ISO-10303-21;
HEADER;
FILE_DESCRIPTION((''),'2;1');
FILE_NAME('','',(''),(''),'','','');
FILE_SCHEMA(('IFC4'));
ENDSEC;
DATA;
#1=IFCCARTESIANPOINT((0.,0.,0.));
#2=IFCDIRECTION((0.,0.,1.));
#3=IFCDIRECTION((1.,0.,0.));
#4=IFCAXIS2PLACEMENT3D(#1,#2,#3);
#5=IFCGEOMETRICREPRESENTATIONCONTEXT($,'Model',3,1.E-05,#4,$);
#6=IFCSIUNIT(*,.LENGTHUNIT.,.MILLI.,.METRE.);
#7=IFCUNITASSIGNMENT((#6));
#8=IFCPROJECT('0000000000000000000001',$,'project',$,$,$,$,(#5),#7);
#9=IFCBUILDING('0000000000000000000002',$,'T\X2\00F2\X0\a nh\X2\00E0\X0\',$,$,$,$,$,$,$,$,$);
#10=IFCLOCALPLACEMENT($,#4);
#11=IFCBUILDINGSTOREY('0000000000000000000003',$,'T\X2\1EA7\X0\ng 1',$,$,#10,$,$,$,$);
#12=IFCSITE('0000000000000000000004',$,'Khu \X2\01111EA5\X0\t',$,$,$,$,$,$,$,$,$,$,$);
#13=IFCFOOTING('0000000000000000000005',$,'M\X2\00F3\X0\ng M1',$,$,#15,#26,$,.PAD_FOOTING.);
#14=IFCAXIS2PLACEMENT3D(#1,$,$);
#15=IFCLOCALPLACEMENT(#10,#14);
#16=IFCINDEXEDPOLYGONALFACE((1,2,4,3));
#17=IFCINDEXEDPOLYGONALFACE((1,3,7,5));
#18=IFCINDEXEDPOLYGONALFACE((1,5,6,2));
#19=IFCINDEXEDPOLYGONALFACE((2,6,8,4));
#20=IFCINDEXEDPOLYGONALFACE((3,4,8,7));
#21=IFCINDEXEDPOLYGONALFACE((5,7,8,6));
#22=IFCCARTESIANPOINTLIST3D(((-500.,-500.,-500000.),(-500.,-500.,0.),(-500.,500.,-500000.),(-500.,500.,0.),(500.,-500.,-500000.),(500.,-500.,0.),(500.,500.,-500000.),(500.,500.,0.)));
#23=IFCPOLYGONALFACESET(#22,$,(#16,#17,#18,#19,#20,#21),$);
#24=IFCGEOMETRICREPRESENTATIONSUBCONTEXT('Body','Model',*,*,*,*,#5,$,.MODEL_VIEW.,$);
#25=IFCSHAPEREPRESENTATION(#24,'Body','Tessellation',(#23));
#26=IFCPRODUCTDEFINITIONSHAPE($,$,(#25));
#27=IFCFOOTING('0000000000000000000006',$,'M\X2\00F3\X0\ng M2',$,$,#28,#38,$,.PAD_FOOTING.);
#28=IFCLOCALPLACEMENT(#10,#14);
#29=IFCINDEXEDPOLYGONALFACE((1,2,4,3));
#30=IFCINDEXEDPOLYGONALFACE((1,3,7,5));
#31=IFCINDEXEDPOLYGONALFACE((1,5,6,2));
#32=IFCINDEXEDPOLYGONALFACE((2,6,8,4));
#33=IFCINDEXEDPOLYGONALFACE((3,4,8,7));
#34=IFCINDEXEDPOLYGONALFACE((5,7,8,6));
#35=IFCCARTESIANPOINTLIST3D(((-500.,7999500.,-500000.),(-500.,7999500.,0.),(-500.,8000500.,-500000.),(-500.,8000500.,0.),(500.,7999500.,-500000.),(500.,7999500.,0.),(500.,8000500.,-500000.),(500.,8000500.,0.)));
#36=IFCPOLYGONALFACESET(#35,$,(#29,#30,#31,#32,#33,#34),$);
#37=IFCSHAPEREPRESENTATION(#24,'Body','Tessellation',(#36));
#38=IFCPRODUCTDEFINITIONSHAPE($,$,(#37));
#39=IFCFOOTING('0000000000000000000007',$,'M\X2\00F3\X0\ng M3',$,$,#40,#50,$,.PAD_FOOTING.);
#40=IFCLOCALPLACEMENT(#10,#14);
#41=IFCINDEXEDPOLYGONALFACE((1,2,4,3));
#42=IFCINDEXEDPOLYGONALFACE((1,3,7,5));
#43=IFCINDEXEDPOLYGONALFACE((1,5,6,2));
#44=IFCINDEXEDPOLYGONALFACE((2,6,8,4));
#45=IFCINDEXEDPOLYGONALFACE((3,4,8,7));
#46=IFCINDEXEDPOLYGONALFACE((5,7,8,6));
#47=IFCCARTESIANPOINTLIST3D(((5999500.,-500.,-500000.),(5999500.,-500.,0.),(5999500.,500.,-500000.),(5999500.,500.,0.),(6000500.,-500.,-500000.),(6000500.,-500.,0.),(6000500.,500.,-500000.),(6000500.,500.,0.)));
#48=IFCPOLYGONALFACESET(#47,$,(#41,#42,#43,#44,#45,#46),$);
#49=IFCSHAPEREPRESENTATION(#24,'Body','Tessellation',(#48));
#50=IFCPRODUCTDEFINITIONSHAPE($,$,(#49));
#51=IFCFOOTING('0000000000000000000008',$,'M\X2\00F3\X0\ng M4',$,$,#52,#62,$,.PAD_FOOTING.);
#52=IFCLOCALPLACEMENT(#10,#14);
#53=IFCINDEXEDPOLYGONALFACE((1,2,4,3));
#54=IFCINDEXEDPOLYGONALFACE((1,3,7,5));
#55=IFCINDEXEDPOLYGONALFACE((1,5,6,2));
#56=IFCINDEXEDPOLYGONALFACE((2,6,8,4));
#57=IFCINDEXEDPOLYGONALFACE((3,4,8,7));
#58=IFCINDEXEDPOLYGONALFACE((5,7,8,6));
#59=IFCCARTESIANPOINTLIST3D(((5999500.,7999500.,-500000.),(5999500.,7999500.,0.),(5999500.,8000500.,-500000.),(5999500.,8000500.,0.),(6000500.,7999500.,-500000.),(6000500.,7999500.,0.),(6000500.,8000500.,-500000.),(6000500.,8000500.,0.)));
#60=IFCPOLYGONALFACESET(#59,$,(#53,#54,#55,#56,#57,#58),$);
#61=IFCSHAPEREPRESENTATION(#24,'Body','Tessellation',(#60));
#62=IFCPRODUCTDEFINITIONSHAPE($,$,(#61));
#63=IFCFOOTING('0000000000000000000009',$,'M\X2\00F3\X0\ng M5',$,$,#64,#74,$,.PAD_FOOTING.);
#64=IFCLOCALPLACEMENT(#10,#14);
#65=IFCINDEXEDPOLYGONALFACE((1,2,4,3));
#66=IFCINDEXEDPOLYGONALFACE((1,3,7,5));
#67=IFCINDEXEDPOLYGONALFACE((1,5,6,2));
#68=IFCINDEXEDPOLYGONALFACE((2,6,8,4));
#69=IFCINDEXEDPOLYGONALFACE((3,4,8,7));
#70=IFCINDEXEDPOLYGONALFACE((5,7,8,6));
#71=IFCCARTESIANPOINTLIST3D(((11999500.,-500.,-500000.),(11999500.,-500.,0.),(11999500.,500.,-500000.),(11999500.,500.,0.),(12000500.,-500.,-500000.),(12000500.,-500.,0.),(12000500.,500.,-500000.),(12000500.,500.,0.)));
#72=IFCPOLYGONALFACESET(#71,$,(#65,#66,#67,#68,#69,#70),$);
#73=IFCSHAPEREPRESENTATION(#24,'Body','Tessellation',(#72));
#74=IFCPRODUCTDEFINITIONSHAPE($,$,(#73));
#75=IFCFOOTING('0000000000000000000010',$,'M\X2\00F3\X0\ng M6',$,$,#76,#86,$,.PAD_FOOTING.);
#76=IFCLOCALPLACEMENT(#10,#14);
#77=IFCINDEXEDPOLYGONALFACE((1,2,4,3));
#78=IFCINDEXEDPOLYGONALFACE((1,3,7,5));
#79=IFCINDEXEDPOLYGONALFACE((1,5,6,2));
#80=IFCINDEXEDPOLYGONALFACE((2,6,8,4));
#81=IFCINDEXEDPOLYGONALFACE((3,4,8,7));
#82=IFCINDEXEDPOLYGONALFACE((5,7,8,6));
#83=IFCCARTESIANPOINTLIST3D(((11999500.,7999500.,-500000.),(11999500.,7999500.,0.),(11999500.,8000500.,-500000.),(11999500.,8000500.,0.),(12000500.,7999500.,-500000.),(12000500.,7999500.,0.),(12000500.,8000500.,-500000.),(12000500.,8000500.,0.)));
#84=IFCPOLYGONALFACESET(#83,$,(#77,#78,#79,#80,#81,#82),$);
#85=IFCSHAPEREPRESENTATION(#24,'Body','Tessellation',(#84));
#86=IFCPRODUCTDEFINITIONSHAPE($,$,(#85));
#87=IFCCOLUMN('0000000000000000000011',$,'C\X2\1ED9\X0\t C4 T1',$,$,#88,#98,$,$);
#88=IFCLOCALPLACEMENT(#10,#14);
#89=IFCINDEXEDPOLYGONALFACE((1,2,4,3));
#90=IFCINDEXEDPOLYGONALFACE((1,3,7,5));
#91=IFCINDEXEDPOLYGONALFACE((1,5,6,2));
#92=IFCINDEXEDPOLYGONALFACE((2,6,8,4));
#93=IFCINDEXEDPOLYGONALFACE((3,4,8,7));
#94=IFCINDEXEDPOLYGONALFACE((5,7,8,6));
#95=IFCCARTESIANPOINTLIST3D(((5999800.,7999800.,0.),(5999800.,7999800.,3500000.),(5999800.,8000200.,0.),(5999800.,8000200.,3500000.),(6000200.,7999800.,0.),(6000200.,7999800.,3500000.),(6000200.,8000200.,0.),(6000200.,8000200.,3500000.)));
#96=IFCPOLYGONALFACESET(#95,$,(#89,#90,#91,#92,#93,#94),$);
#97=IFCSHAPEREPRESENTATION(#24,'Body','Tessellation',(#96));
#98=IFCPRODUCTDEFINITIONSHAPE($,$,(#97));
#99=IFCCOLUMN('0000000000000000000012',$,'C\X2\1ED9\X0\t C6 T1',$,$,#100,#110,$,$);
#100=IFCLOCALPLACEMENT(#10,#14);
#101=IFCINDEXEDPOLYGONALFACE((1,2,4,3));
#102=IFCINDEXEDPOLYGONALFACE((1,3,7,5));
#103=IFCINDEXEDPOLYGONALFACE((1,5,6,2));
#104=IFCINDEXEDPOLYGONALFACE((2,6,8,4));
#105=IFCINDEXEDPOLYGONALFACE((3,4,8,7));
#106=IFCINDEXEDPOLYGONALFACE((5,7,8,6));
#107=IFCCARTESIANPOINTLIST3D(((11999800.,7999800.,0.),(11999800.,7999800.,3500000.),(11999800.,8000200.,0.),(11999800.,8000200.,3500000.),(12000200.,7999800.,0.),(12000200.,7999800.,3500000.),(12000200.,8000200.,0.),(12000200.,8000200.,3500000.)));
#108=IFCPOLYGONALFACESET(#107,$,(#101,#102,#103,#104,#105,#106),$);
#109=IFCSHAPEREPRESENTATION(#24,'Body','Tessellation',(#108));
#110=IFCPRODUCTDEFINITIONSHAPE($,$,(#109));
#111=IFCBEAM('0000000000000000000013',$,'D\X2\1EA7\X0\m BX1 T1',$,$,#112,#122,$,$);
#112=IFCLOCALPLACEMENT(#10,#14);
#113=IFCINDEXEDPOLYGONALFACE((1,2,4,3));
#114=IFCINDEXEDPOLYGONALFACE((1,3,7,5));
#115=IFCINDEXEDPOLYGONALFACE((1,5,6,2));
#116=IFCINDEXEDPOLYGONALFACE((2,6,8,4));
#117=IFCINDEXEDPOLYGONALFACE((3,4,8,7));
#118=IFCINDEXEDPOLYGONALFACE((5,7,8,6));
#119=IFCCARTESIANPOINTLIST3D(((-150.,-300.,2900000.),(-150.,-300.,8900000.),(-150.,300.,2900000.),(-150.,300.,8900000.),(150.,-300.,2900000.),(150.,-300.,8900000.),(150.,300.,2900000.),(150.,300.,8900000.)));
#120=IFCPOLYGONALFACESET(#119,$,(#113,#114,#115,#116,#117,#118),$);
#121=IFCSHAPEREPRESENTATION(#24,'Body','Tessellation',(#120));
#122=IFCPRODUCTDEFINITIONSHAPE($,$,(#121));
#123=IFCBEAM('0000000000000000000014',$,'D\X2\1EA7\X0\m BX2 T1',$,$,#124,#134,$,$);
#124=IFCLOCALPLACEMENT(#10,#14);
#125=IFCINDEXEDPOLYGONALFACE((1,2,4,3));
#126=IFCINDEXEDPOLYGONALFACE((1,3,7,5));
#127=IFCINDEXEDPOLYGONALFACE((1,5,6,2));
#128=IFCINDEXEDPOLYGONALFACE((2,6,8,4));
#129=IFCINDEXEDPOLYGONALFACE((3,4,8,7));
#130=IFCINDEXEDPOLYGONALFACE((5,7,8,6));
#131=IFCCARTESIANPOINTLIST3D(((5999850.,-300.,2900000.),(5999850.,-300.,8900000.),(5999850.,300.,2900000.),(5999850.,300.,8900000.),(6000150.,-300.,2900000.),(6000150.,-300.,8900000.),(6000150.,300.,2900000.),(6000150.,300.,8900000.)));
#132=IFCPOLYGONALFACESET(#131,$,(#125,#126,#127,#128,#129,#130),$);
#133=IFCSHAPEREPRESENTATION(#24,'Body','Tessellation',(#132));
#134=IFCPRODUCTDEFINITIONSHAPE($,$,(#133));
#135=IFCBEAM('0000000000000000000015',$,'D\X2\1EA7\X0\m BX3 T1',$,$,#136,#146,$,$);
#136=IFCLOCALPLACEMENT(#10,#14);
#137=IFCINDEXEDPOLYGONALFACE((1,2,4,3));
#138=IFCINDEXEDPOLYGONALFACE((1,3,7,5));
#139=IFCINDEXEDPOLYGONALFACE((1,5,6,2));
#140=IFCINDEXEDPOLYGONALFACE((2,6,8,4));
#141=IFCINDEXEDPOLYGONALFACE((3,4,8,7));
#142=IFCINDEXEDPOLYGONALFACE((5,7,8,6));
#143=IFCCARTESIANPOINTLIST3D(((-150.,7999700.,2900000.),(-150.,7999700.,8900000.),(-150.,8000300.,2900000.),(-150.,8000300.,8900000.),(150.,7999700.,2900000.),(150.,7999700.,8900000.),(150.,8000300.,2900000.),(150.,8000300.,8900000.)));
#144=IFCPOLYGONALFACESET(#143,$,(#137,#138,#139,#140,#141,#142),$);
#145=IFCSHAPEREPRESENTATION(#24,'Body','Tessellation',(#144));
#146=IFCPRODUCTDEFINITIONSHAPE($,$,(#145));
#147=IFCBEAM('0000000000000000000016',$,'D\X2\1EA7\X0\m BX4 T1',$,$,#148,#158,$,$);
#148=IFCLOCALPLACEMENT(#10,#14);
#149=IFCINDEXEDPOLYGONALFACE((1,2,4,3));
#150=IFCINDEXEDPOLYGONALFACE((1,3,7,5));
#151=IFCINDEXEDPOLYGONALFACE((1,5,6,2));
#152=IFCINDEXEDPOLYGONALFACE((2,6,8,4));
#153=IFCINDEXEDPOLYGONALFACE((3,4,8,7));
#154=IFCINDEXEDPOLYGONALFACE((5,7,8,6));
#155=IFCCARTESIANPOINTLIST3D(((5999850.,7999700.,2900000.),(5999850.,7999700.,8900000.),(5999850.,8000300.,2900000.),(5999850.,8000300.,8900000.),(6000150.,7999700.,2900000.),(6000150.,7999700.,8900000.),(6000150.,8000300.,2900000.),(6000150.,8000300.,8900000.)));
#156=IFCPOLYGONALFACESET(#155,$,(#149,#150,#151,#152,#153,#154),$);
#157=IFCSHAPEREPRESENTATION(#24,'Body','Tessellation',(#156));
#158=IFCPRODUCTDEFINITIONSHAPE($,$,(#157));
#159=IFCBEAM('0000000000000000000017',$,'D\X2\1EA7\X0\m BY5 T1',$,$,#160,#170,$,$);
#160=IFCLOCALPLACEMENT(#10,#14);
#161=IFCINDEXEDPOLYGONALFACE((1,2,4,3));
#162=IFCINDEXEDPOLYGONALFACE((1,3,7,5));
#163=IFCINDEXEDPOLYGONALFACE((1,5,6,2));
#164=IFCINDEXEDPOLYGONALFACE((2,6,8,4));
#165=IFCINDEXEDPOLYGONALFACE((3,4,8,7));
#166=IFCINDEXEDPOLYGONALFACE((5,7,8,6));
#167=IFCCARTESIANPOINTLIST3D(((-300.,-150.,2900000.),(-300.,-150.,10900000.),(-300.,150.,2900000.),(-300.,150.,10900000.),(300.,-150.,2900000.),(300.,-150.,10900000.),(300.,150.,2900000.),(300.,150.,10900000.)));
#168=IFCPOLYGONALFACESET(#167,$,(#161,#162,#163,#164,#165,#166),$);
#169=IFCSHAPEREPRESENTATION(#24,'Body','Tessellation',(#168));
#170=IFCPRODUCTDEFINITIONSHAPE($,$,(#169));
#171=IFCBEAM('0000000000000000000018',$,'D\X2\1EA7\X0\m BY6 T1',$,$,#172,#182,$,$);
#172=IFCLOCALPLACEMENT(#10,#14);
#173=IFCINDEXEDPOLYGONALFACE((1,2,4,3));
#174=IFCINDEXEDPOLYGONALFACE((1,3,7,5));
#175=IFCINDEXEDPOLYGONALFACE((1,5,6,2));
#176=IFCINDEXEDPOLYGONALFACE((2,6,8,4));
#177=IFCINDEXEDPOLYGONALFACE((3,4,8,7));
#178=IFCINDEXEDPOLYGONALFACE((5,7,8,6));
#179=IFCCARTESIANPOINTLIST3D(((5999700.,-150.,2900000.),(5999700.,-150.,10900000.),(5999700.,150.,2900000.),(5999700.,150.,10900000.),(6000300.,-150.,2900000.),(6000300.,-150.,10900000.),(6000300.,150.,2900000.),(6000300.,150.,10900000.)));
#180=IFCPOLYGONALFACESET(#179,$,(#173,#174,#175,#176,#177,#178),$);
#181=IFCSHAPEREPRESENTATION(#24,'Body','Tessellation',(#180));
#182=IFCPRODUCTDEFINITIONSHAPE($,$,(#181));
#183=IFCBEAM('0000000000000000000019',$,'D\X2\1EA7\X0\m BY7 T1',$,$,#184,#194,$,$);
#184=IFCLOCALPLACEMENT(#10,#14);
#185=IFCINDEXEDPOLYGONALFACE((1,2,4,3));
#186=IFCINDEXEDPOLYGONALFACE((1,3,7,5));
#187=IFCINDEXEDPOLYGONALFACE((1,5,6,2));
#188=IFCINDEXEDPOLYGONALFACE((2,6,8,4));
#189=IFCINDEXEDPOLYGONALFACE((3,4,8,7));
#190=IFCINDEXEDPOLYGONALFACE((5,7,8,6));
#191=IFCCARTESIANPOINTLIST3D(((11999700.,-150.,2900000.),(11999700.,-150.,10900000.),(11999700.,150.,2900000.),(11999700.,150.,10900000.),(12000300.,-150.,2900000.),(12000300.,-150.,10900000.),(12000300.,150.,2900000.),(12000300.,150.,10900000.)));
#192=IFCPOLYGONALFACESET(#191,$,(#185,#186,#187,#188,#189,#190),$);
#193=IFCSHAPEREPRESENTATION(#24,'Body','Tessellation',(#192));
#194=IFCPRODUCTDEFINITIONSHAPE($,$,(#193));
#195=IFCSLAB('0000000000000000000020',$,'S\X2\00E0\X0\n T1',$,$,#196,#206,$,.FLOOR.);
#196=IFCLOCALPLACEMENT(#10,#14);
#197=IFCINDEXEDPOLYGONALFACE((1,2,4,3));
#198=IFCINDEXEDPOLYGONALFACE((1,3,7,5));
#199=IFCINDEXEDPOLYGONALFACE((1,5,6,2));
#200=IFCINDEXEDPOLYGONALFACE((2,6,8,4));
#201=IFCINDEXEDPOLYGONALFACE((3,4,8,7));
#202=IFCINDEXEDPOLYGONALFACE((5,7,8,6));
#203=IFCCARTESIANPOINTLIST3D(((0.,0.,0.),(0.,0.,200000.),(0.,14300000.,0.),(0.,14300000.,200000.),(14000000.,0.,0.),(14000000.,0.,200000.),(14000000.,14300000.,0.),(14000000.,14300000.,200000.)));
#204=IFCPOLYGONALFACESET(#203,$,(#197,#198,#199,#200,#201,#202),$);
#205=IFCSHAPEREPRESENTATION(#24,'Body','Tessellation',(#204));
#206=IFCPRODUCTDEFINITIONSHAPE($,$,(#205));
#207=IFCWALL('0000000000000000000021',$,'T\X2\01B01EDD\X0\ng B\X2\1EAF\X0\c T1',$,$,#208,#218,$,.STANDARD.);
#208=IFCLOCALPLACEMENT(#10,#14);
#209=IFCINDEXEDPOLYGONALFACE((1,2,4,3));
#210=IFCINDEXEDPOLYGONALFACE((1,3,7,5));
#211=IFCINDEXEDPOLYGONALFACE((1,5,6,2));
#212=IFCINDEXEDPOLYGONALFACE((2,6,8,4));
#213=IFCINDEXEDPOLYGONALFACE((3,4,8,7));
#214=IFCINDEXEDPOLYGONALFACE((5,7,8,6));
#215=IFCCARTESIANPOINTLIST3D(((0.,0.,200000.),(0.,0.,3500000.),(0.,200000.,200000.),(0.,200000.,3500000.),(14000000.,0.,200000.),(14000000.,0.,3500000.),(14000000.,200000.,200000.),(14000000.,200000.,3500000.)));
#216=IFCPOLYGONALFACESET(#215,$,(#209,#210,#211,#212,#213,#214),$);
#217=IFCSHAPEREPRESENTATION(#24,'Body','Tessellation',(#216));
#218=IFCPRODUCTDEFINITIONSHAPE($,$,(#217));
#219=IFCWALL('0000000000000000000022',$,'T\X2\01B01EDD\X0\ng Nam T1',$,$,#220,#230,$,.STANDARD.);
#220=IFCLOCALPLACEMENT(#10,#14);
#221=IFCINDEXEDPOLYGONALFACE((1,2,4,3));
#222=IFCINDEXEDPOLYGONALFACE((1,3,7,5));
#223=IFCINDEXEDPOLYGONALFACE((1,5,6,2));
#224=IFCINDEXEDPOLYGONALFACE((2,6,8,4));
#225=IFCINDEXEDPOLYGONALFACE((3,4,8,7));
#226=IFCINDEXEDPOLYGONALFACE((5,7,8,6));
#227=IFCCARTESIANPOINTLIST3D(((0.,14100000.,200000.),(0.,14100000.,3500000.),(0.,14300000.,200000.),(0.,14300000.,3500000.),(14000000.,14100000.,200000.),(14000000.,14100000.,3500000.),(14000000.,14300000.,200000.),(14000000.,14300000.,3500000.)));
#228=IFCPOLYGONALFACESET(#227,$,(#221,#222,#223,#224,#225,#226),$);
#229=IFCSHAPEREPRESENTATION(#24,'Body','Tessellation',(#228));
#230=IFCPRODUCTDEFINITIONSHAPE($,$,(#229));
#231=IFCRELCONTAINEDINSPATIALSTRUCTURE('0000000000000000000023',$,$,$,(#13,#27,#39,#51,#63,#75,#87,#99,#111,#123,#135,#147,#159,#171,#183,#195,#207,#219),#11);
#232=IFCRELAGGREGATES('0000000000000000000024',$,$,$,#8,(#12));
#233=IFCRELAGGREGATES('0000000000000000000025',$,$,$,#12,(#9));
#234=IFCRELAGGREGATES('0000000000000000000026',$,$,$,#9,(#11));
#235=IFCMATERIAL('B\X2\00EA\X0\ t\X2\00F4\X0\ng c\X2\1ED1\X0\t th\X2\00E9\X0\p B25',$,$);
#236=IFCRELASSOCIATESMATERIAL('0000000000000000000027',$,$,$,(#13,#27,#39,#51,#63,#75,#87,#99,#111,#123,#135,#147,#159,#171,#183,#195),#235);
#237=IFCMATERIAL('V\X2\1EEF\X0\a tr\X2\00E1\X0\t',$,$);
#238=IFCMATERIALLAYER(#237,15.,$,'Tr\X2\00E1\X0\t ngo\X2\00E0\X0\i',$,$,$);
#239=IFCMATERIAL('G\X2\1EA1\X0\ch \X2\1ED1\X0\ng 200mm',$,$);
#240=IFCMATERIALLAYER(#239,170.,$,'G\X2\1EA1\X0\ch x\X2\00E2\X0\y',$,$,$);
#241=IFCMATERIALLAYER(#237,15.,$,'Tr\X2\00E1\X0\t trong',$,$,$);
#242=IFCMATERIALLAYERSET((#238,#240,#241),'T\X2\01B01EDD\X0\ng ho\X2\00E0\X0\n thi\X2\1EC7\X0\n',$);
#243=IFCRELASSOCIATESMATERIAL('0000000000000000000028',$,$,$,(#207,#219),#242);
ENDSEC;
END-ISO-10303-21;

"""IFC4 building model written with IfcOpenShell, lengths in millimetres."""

from ifc_helpers import new_model, entity, si_unit, frame, origin_with_axes, place, context, subcontext, project, spatial, indexed_curve, outline, extrude, material, layer, layer_set, layer_usage, element, save


model = new_model("IFC4")

# Units and contexts
model_context = context("Model", 3, precision=1e-05, world=origin_with_axes())
body_context = subcontext(model_context, "Body", "Model", "MODEL_VIEW")
ifc_project = project(units=[si_unit("LENGTHUNIT", "METRE", prefix="MILLI")], contexts=[model_context])

# Site, building, storey
site = spatial("IfcSite", under=ifc_project, Name="Khu đất")
building = spatial("IfcBuilding", under=site, Name="Tòa nhà")
storey_placement = place(None, origin_with_axes())
storey = spatial("IfcBuildingStorey", under=building, at=storey_placement, Name="Tầng 1")

# Footings
ifc_material_1 = material(Name="Bê tông cốt thép B25")
for number, where, z_axis, x_axis, name in (
    (1, (0.0, 0.0, -500000.0), (0.0, 0.0, 1.0), (1.0, 0.0, 0.0), "Móng M1"),
    (2, (0.0, 8000000.0, -500000.0), (0.0, 0.0, 1.0), (1.0, 0.0, 0.0), "Móng M2"),
    (3, (6000000.0, 0.0, -500000.0), (0.0, 0.0, 1.0), (1.0, 0.0, 0.0), "Móng M3"),
    (4, (6000000.0, 8000000.0, -500000.0), (0.0, 0.0, 1.0), (1.0, 0.0, 0.0), "Móng M4"),
    (5, (12000000.0, 0.0, -500000.0), (0.0, 0.0, 1.0), (1.0, 0.0, 0.0), "Móng M5"),
    (6, (12000000.0, 8000000.0, -500000.0), (0.0, 0.0, 1.0), (1.0, 0.0, 0.0), "Móng M6"),
):
    element("IfcFooting", number, at=place(storey_placement, frame(where, z_axis=z_axis, x_axis=x_axis)), inside=storey, material=ifc_material_1, Name=name, PredefinedType="PAD_FOOTING", context=body_context, shape_type="SweptSolid", body=[
        extrude(entity("IfcRectangleProfileDef", None, None, None, 1000.0, 1000.0), origin_with_axes(), (0.0, 0.0, 1.0), 500000.0),
    ])

# Columns
for number, where, z_axis, x_axis, name in (
    (7, (6000000.0, 8000000.0, 0.0), (0.0, 0.0, 1.0), (1.0, 0.0, 0.0), "Cột C4 T1"),
    (8, (12000000.0, 8000000.0, 0.0), (0.0, 0.0, 1.0), (1.0, 0.0, 0.0), "Cột C6 T1"),
):
    element("IfcColumn", number, at=place(storey_placement, frame(where, z_axis=z_axis, x_axis=x_axis)), inside=storey, material=ifc_material_1, Name=name, context=body_context, shape_type="SweptSolid", body=[
        extrude(entity("IfcRectangleProfileDef", None, None, None, 400.0, 400.0), origin_with_axes(), (0.0, 0.0, 1.0), 3500000.0),
    ])

# Beams
for number, where, z_axis, x_axis, name in (
    (9, (0.0, 0.0, 2900000.0), (0.0, 0.0, 1.0), (1.0, 0.0, 0.0), "Dầm BX1 T1"),
    (10, (6000000.0, 0.0, 2900000.0), (0.0, 0.0, 1.0), (1.0, 0.0, 0.0), "Dầm BX2 T1"),
    (11, (0.0, 8000000.0, 2900000.0), (0.0, 0.0, 1.0), (1.0, 0.0, 0.0), "Dầm BX3 T1"),
    (12, (6000000.0, 8000000.0, 2900000.0), (0.0, 0.0, 1.0), (1.0, 0.0, 0.0), "Dầm BX4 T1"),
):
    element("IfcBeam", number, at=place(storey_placement, frame(where, z_axis=z_axis, x_axis=x_axis)), inside=storey, material=ifc_material_1, Name=name, context=body_context, shape_type="SweptSolid", body=[
        extrude(entity("IfcRectangleProfileDef", None, None, None, 300.0, 600.0), origin_with_axes(), (0.0, 0.0, 1.0), 6000000.0),
    ])
for number, where, z_axis, x_axis, name in (
    (13, (0.0, 0.0, 2900000.0), (0.0, 0.0, 1.0), (0.0, 1.0, 0.0), "Dầm BY5 T1"),
    (14, (6000000.0, 0.0, 2900000.0), (0.0, 0.0, 1.0), (0.0, 1.0, 0.0), "Dầm BY6 T1"),
    (15, (12000000.0, 0.0, 2900000.0), (0.0, 0.0, 1.0), (0.0, 1.0, 0.0), "Dầm BY7 T1"),
):
    element("IfcBeam", number, at=place(storey_placement, frame(where, z_axis=z_axis, x_axis=x_axis)), inside=storey, material=ifc_material_1, Name=name, context=body_context, shape_type="SweptSolid", body=[
        extrude(entity("IfcRectangleProfileDef", None, None, None, 300.0, 600.0), origin_with_axes(), (0.0, 0.0, 1.0), 8000000.0),
    ])

# Slab
slab_placement = place(storey_placement, origin_with_axes())
element("IfcSlab", 16, at=slab_placement, inside=storey, material=ifc_material_1, Name="Sàn T1", PredefinedType="FLOOR", context=body_context, shape_type="SweptSolid", body=[
    extrude(outline(indexed_curve([(0.0, 0.0), (14000000.0, 0.0), (14000000.0, 14300000.0), (0.0, 14300000.0), (0.0, 0.0)])), None, (0.0, 0.0, 1.0), 200000.0),
])

# Walls
ifc_material_2 = material(Name="Vữa trát")
ifc_layer_1 = layer(ifc_material_2, 15.0, Name="Trát ngoài")
ifc_material_3 = material(Name="Gạch ống 200mm")
ifc_layer_2 = layer(ifc_material_3, 170.0, Name="Gạch xây")
ifc_layer_3 = layer(ifc_material_2, 15.0, Name="Trát trong")
ifc_layer_set = layer_set([ifc_layer_1, ifc_layer_2, ifc_layer_3], Name="Tường hoàn thiện")
ifc_layer_usage_1 = layer_usage(ifc_layer_set, "AXIS2", "POSITIVE", 0.0)
wall_1_placement = place(storey_placement, frame((0.0, 0.0, 200000.0), z_axis=(0.0, 0.0, 1.0), x_axis=(1.0, 0.0, 0.0)))
element("IfcWall", 17, at=wall_1_placement, inside=storey, material=ifc_layer_usage_1, Name="Tường Bắc T1", PredefinedType="STANDARD", context=body_context, shape_type="SweptSolid", body=[
    extrude(outline(indexed_curve([(0.0, 0.0), (0.0, 200000.0), (14000000.0, 200000.0), (14000000.0, 0.0), (0.0, 0.0)], self_intersect=False)), origin_with_axes(), (0.0, 0.0, 1.0), 3300000.0),
])
ifc_layer_usage_2 = layer_usage(ifc_layer_set, "AXIS2", "POSITIVE", 0.0)
wall_2_placement = place(storey_placement, frame((0.0, 14100000.0, 200000.0), z_axis=(0.0, 0.0, 1.0), x_axis=(1.0, 0.0, 0.0)))
element("IfcWall", 18, at=wall_2_placement, inside=storey, material=ifc_layer_usage_2, Name="Tường Nam T1", PredefinedType="STANDARD", context=body_context, shape_type="SweptSolid", body=[
    extrude(outline(indexed_curve([(0.0, 0.0), (0.0, 200000.0), (14000000.0, 200000.0), (14000000.0, 0.0), (0.0, 0.0)], self_intersect=False)), origin_with_axes(), (0.0, 0.0, 1.0), 3300000.0),
])

save(model, "model.ifc")
